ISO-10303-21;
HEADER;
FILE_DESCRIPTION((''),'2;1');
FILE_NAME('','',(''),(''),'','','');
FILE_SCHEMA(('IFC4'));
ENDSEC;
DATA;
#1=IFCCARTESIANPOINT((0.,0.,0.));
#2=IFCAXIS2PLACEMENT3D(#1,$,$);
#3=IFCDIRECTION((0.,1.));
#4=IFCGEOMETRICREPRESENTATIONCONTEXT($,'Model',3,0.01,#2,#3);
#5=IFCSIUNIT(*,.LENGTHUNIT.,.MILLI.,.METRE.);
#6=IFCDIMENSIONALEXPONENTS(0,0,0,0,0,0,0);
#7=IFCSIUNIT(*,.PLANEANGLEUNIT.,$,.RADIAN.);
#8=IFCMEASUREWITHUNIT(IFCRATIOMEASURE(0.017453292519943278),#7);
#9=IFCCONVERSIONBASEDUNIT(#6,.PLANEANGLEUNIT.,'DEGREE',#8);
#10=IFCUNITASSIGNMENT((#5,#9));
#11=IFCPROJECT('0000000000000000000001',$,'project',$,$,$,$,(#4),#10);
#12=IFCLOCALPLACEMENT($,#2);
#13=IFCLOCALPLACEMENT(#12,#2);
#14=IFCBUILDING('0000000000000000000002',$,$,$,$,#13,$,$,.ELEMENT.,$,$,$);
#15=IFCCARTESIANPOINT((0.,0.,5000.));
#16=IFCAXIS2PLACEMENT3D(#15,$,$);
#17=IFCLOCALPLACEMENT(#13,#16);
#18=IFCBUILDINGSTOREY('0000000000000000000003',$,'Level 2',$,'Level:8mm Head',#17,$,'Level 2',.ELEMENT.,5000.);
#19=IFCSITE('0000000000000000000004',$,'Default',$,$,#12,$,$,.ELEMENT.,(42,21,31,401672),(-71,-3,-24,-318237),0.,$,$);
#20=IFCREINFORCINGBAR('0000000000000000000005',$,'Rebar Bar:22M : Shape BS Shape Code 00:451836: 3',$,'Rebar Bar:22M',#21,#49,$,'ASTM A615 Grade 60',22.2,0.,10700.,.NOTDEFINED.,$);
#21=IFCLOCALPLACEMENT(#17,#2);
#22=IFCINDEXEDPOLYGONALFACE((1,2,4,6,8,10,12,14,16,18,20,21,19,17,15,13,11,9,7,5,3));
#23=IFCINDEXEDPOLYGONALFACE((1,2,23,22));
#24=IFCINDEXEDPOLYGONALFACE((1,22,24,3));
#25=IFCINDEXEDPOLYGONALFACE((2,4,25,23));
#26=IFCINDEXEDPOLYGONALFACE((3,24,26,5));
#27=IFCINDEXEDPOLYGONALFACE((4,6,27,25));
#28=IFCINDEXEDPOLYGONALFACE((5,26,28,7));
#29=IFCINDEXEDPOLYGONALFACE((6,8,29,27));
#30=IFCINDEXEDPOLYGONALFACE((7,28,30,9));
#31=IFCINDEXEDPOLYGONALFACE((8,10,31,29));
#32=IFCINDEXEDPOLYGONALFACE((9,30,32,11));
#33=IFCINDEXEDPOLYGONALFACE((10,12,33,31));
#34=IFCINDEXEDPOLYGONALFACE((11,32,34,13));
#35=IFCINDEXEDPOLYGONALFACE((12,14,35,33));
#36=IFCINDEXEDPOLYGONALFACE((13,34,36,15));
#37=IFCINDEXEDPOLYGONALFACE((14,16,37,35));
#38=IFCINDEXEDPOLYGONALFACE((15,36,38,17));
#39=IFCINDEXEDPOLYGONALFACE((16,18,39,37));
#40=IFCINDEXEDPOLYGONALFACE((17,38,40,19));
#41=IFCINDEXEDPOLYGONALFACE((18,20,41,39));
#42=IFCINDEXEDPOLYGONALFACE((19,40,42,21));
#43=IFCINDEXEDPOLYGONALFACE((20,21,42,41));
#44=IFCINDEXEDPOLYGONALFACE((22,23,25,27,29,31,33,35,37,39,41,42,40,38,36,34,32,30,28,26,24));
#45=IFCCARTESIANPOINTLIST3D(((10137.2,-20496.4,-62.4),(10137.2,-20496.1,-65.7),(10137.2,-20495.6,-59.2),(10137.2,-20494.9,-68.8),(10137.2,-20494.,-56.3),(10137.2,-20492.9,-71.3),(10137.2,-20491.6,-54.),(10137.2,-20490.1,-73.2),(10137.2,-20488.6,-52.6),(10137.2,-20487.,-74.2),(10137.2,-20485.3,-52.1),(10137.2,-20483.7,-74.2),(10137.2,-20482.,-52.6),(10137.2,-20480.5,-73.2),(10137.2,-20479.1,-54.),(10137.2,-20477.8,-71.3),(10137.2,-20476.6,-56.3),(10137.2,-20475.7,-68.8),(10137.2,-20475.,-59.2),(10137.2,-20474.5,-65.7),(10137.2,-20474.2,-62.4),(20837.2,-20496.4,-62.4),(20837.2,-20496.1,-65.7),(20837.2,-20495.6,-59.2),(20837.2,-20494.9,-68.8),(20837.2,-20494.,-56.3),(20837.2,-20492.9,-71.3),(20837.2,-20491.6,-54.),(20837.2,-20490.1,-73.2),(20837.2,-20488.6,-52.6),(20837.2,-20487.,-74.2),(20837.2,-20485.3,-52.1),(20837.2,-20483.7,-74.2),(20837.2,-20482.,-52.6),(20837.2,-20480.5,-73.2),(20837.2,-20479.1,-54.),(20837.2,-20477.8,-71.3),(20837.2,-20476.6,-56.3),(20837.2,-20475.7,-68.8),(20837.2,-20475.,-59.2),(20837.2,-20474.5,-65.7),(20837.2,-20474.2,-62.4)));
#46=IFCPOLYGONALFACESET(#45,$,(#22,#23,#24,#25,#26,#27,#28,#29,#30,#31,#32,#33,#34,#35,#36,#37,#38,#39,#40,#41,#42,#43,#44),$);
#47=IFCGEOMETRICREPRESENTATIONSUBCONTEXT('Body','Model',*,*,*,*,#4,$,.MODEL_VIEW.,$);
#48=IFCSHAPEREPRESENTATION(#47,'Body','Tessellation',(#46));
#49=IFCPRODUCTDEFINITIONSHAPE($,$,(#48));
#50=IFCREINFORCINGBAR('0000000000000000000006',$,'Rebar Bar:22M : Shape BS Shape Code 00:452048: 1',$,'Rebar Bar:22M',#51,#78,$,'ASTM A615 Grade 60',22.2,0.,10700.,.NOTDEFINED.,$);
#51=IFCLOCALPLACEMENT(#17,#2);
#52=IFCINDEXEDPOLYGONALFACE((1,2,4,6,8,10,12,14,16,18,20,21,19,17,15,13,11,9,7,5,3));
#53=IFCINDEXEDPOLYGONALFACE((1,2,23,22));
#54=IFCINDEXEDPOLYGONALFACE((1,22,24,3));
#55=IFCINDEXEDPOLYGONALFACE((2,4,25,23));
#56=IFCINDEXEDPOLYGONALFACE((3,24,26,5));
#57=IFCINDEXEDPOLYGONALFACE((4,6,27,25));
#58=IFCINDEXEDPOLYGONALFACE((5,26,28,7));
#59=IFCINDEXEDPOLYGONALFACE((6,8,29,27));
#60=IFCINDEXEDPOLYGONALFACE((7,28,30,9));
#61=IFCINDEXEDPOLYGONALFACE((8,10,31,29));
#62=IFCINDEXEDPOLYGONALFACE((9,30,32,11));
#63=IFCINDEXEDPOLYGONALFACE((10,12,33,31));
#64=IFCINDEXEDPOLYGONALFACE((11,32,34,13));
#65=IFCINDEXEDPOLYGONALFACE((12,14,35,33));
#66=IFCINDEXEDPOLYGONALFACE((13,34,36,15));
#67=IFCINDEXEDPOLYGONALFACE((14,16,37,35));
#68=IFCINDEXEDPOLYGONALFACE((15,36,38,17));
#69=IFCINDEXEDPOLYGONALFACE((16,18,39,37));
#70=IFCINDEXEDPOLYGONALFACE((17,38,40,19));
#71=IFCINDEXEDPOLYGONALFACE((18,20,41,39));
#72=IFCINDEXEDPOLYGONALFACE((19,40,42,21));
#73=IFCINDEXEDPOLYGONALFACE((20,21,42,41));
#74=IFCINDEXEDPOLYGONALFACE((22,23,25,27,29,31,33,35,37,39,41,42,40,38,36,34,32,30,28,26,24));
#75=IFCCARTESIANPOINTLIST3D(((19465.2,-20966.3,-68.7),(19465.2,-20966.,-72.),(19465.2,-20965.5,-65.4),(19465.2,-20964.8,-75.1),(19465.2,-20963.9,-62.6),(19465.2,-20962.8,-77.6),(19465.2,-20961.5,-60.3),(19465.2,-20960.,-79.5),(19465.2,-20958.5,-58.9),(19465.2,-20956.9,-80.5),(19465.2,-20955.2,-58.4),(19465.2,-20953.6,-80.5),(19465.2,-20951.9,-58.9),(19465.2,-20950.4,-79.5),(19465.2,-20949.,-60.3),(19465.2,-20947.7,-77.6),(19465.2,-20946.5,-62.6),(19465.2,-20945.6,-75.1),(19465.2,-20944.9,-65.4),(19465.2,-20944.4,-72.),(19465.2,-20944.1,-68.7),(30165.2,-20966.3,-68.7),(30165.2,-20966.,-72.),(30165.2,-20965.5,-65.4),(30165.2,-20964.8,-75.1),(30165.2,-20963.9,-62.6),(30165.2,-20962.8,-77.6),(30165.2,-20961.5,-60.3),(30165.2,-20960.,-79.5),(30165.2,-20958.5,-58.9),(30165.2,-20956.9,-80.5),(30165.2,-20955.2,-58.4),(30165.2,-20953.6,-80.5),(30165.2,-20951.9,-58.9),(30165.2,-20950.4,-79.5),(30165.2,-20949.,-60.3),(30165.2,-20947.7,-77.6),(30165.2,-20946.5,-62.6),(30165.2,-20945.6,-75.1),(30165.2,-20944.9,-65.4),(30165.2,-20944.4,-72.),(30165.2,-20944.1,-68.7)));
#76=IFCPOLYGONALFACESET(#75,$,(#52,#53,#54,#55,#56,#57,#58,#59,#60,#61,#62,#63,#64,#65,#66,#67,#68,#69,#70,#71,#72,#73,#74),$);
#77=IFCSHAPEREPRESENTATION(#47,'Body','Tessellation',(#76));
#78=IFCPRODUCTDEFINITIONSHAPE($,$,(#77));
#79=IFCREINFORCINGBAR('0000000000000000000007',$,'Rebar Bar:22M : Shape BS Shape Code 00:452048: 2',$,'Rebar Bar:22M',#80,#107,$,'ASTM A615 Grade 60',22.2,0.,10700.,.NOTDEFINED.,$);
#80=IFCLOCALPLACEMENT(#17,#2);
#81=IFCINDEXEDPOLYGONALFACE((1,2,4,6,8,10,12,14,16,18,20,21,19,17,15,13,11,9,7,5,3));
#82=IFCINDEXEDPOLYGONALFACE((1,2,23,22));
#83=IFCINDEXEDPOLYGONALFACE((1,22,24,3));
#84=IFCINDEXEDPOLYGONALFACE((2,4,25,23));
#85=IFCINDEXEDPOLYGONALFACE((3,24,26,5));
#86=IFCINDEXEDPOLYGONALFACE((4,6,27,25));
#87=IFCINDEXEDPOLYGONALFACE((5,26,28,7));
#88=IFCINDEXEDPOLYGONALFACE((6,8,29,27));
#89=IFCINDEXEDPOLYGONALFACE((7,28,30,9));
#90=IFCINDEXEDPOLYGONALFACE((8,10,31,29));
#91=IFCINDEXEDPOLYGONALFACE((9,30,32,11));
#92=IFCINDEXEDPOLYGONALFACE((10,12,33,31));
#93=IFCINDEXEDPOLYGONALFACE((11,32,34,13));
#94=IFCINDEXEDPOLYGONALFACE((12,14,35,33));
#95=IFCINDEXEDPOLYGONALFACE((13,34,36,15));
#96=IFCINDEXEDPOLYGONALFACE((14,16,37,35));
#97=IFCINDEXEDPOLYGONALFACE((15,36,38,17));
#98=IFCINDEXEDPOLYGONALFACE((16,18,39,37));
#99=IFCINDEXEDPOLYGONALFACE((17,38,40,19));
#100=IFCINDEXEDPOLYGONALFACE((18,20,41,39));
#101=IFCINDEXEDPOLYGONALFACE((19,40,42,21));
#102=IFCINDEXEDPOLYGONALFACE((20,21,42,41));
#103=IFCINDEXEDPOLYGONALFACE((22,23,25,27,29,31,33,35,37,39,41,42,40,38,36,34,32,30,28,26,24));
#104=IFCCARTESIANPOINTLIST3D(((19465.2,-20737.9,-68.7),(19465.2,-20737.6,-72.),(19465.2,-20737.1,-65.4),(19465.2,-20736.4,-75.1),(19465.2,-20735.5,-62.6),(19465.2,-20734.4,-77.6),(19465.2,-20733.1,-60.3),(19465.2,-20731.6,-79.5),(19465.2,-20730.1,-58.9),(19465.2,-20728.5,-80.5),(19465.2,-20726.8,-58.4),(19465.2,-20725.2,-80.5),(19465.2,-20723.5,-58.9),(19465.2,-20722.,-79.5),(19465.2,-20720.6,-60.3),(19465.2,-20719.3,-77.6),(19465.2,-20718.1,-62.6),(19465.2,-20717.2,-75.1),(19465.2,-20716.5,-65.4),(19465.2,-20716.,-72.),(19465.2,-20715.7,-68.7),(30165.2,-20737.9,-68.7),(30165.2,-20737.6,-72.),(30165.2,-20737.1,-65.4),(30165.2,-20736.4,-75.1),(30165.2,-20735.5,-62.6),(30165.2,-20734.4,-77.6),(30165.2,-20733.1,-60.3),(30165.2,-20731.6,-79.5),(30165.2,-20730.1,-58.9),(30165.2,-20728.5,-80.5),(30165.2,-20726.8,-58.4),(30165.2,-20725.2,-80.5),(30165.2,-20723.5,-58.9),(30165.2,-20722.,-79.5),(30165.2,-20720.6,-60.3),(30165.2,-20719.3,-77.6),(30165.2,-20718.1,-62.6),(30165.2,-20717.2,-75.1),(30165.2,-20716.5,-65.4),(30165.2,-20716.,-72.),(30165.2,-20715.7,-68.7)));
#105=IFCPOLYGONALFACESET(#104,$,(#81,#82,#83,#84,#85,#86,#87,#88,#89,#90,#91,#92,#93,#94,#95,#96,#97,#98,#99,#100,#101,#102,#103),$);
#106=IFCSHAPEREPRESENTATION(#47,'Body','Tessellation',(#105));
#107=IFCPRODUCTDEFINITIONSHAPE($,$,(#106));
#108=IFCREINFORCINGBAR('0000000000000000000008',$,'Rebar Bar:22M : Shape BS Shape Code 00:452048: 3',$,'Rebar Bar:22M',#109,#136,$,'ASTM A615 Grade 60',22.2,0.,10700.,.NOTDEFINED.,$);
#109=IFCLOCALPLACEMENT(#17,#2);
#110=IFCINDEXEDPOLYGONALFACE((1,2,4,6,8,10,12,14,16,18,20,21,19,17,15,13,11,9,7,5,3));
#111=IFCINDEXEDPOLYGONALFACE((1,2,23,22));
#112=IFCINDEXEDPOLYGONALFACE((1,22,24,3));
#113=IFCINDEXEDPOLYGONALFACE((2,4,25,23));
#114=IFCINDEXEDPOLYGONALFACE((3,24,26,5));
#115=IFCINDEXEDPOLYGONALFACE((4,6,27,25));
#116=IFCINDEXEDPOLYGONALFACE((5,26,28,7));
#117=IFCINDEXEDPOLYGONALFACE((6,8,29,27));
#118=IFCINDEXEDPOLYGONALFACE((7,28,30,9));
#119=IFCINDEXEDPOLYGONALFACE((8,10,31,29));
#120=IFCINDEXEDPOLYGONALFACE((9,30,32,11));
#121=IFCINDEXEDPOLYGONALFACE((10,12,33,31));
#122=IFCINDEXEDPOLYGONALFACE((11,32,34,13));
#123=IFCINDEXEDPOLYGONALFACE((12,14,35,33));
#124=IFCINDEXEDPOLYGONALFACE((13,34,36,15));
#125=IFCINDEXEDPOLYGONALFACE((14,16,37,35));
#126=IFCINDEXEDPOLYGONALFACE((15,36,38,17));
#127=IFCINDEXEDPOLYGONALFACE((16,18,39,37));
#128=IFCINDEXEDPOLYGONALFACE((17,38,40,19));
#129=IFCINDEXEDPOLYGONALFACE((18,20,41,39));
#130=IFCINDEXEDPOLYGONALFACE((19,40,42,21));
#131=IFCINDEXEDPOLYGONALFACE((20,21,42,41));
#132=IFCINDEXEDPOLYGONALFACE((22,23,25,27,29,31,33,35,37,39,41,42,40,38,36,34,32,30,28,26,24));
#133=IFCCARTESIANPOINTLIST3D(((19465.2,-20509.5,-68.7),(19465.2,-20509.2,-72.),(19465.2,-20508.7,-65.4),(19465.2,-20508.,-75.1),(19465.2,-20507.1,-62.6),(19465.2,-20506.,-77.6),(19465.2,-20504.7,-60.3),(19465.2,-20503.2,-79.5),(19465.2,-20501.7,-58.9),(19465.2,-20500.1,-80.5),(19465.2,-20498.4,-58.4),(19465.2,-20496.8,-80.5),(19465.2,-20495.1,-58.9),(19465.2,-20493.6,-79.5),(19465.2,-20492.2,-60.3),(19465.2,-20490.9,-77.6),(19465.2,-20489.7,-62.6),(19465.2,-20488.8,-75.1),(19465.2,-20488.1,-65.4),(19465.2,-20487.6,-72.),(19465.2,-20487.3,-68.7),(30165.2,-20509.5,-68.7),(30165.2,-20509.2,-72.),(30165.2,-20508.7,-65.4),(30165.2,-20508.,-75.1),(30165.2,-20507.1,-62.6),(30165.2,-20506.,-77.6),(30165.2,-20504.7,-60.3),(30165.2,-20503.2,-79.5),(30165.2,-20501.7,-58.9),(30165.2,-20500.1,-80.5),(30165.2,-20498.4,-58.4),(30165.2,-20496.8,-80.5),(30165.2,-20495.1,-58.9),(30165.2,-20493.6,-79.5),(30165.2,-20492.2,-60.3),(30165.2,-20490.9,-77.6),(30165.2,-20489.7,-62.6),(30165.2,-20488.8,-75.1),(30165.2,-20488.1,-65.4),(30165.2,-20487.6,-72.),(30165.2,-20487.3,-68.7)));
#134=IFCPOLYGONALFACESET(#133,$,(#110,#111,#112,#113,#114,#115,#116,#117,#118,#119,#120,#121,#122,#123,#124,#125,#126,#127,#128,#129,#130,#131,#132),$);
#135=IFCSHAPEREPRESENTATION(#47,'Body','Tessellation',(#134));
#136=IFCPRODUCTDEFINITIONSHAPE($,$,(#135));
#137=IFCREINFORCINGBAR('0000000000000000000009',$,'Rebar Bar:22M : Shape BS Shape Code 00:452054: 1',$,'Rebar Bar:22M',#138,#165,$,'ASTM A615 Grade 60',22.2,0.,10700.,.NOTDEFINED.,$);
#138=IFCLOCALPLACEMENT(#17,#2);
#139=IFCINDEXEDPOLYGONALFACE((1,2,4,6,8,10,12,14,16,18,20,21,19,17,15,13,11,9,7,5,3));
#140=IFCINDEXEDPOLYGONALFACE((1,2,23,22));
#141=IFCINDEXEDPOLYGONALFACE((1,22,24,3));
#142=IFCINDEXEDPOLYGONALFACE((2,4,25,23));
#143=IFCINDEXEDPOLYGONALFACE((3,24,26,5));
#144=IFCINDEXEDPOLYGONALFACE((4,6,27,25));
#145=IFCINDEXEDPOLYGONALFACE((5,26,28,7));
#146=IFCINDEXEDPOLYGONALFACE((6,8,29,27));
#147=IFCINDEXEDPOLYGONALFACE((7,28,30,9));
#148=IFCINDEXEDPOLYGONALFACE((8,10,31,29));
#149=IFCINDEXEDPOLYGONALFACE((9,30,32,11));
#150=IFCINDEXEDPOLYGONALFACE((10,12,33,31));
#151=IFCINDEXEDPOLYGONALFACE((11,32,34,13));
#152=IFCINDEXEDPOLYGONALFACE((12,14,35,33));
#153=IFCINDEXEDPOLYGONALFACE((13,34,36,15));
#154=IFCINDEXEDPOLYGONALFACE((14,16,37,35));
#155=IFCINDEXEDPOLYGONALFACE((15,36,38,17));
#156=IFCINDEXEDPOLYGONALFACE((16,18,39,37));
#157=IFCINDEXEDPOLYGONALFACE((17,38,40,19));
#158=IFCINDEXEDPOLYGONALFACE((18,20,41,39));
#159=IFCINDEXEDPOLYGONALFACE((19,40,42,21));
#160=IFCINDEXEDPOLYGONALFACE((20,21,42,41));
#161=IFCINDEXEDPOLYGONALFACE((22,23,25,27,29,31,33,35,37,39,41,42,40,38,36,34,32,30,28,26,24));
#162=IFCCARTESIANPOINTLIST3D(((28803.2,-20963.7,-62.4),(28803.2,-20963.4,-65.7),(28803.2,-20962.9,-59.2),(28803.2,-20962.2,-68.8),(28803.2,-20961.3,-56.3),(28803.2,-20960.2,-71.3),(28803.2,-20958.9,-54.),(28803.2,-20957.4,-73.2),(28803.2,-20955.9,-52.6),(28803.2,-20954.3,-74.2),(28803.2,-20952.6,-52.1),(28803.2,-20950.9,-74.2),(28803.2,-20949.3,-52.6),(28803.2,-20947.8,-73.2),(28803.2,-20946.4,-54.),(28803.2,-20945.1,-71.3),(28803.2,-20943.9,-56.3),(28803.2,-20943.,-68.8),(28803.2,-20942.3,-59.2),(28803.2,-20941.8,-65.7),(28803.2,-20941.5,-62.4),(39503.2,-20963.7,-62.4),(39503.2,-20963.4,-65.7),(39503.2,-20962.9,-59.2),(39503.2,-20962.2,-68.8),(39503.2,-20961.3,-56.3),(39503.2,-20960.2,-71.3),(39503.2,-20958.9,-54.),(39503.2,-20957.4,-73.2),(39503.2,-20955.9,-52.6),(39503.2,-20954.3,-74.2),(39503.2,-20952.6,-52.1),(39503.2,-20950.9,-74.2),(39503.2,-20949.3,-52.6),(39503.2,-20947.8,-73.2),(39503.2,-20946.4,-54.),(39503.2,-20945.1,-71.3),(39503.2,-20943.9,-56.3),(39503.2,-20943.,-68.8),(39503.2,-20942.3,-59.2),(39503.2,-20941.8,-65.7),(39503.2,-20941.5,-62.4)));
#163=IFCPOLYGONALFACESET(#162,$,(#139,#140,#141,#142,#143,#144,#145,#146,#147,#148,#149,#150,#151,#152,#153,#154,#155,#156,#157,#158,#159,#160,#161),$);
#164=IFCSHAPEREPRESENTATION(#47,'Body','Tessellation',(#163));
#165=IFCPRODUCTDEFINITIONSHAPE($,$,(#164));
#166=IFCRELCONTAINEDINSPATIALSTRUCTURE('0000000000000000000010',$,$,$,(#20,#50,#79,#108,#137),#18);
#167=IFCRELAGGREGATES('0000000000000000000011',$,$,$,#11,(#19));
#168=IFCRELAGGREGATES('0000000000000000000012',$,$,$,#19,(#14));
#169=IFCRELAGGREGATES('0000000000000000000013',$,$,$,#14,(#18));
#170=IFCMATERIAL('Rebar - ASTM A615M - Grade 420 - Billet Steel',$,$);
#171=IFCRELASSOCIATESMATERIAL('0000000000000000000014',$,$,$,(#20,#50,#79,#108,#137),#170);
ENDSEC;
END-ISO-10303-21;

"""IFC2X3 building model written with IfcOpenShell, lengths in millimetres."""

from ifc_helpers import new_model, entity, si_unit, converted_unit, direction, frame, origin, place, context, subcontext, project, spatial, material, element, save


model = new_model("IFC2X3")

# Units and contexts
model_context = context("Model", 3, precision=0.01, world=origin(), true_north=direction((0.0, 1.0)))
body_context = subcontext(model_context, "Body", "Model", "MODEL_VIEW")
ifc_project = project(units=[si_unit("LENGTHUNIT", "METRE", prefix="MILLI"), converted_unit("PLANEANGLEUNIT", "DEGREE", entity("IfcRatioMeasure", 0.017453292519943278), si_unit("PLANEANGLEUNIT", "RADIAN"), dimensions=[0, 0, 0, 0, 0, 0, 0])], contexts=[model_context])

# Site, building, storey
site_placement = place(None, origin())
site = spatial("IfcSite", under=ifc_project, at=site_placement, Name="Default", CompositionType="ELEMENT", RefLatitude=(42, 21, 31, 401672), RefLongitude=(-71, -3, -24, -318237), RefElevation=0.0)
building_placement = place(site_placement, origin())
building = spatial("IfcBuilding", under=site, at=building_placement, CompositionType="ELEMENT")
storey_placement = place(building_placement, frame((0.0, 0.0, 5000.0)))
storey = spatial("IfcBuildingStorey", under=building, at=storey_placement, Name="Level 2", ObjectType="Level:8mm Head", LongName="Level 2", CompositionType="ELEMENT", Elevation=5000.0)

# Reinforcing bars
ifc_material_1 = material(Name="Rebar - ASTM A615M - Grade 420 - Billet Steel")
reinforcing_bar_1_placement = place(storey_placement, origin())
element("IfcReinforcingBar", 1, at=reinforcing_bar_1_placement, inside=storey, material=ifc_material_1, Name="Rebar Bar:22M : Shape BS Shape Code 00:451836: 3", SteelGrade="ASTM A615 Grade 60", ObjectType="Rebar Bar:22M", BarLength=10700.0, BarRole="NOTDEFINED", CrossSectionArea=0.0, NominalDiameter=22.2, context=body_context, shape_type="AdvancedSweptSolid", body=[
    entity("IfcSweptDiskSolid", entity("IfcCompositeCurve", [entity("IfcCompositeCurveSegment", "CONTINUOUS", True, entity("IfcPolyline", [entity("IfcCartesianPoint", [10137.2, -20485.3, -63.2]), entity("IfcCartesianPoint", [20837.2, -20485.3, -63.2])]))], False), 11.1, None, 0.0, 1.0),
])
reinforcing_bar_2_placement = place(storey_placement, origin())
element("IfcReinforcingBar", 2, at=reinforcing_bar_2_placement, inside=storey, material=ifc_material_1, Name="Rebar Bar:22M : Shape BS Shape Code 00:452048: 1", SteelGrade="ASTM A615 Grade 60", ObjectType="Rebar Bar:22M", BarLength=10700.0, BarRole="NOTDEFINED", CrossSectionArea=0.0, NominalDiameter=22.2, context=body_context, shape_type="AdvancedSweptSolid", body=[
    entity("IfcSweptDiskSolid", entity("IfcCompositeCurve", [entity("IfcCompositeCurveSegment", "CONTINUOUS", True, entity("IfcPolyline", [entity("IfcCartesianPoint", [19465.2, -20955.2, -69.5]), entity("IfcCartesianPoint", [30165.2, -20955.2, -69.5])]))], False), 11.1, None, 0.0, 1.0),
])
reinforcing_bar_3_placement = place(storey_placement, origin())
element("IfcReinforcingBar", 3, at=reinforcing_bar_3_placement, inside=storey, material=ifc_material_1, Name="Rebar Bar:22M : Shape BS Shape Code 00:452048: 2", SteelGrade="ASTM A615 Grade 60", ObjectType="Rebar Bar:22M", BarLength=10700.0, BarRole="NOTDEFINED", CrossSectionArea=0.0, NominalDiameter=22.2, context=body_context, shape_type="AdvancedSweptSolid", body=[
    entity("IfcSweptDiskSolid", entity("IfcCompositeCurve", [entity("IfcCompositeCurveSegment", "CONTINUOUS", True, entity("IfcPolyline", [entity("IfcCartesianPoint", [19465.2, -20726.8, -69.5]), entity("IfcCartesianPoint", [30165.2, -20726.8, -69.5])]))], False), 11.1, None, 0.0, 1.0),
])
reinforcing_bar_4_placement = place(storey_placement, origin())
element("IfcReinforcingBar", 4, at=reinforcing_bar_4_placement, inside=storey, material=ifc_material_1, Name="Rebar Bar:22M : Shape BS Shape Code 00:452048: 3", SteelGrade="ASTM A615 Grade 60", ObjectType="Rebar Bar:22M", BarLength=10700.0, BarRole="NOTDEFINED", CrossSectionArea=0.0, NominalDiameter=22.2, context=body_context, shape_type="AdvancedSweptSolid", body=[
    entity("IfcSweptDiskSolid", entity("IfcCompositeCurve", [entity("IfcCompositeCurveSegment", "CONTINUOUS", True, entity("IfcPolyline", [entity("IfcCartesianPoint", [19465.2, -20498.4, -69.5]), entity("IfcCartesianPoint", [30165.2, -20498.4, -69.5])]))], False), 11.1, None, 0.0, 1.0),
])
reinforcing_bar_5_placement = place(storey_placement, origin())
element("IfcReinforcingBar", 5, at=reinforcing_bar_5_placement, inside=storey, material=ifc_material_1, Name="Rebar Bar:22M : Shape BS Shape Code 00:452054: 1", SteelGrade="ASTM A615 Grade 60", ObjectType="Rebar Bar:22M", BarLength=10700.0, BarRole="NOTDEFINED", CrossSectionArea=0.0, NominalDiameter=22.2, context=body_context, shape_type="AdvancedSweptSolid", body=[
    entity("IfcSweptDiskSolid", entity("IfcCompositeCurve", [entity("IfcCompositeCurveSegment", "CONTINUOUS", True, entity("IfcPolyline", [entity("IfcCartesianPoint", [28803.2, -20952.6, -63.2]), entity("IfcCartesianPoint", [39503.2, -20952.6, -63.2])]))], False), 11.1, None, 0.0, 1.0),
])

save(model, "model.ifc")
